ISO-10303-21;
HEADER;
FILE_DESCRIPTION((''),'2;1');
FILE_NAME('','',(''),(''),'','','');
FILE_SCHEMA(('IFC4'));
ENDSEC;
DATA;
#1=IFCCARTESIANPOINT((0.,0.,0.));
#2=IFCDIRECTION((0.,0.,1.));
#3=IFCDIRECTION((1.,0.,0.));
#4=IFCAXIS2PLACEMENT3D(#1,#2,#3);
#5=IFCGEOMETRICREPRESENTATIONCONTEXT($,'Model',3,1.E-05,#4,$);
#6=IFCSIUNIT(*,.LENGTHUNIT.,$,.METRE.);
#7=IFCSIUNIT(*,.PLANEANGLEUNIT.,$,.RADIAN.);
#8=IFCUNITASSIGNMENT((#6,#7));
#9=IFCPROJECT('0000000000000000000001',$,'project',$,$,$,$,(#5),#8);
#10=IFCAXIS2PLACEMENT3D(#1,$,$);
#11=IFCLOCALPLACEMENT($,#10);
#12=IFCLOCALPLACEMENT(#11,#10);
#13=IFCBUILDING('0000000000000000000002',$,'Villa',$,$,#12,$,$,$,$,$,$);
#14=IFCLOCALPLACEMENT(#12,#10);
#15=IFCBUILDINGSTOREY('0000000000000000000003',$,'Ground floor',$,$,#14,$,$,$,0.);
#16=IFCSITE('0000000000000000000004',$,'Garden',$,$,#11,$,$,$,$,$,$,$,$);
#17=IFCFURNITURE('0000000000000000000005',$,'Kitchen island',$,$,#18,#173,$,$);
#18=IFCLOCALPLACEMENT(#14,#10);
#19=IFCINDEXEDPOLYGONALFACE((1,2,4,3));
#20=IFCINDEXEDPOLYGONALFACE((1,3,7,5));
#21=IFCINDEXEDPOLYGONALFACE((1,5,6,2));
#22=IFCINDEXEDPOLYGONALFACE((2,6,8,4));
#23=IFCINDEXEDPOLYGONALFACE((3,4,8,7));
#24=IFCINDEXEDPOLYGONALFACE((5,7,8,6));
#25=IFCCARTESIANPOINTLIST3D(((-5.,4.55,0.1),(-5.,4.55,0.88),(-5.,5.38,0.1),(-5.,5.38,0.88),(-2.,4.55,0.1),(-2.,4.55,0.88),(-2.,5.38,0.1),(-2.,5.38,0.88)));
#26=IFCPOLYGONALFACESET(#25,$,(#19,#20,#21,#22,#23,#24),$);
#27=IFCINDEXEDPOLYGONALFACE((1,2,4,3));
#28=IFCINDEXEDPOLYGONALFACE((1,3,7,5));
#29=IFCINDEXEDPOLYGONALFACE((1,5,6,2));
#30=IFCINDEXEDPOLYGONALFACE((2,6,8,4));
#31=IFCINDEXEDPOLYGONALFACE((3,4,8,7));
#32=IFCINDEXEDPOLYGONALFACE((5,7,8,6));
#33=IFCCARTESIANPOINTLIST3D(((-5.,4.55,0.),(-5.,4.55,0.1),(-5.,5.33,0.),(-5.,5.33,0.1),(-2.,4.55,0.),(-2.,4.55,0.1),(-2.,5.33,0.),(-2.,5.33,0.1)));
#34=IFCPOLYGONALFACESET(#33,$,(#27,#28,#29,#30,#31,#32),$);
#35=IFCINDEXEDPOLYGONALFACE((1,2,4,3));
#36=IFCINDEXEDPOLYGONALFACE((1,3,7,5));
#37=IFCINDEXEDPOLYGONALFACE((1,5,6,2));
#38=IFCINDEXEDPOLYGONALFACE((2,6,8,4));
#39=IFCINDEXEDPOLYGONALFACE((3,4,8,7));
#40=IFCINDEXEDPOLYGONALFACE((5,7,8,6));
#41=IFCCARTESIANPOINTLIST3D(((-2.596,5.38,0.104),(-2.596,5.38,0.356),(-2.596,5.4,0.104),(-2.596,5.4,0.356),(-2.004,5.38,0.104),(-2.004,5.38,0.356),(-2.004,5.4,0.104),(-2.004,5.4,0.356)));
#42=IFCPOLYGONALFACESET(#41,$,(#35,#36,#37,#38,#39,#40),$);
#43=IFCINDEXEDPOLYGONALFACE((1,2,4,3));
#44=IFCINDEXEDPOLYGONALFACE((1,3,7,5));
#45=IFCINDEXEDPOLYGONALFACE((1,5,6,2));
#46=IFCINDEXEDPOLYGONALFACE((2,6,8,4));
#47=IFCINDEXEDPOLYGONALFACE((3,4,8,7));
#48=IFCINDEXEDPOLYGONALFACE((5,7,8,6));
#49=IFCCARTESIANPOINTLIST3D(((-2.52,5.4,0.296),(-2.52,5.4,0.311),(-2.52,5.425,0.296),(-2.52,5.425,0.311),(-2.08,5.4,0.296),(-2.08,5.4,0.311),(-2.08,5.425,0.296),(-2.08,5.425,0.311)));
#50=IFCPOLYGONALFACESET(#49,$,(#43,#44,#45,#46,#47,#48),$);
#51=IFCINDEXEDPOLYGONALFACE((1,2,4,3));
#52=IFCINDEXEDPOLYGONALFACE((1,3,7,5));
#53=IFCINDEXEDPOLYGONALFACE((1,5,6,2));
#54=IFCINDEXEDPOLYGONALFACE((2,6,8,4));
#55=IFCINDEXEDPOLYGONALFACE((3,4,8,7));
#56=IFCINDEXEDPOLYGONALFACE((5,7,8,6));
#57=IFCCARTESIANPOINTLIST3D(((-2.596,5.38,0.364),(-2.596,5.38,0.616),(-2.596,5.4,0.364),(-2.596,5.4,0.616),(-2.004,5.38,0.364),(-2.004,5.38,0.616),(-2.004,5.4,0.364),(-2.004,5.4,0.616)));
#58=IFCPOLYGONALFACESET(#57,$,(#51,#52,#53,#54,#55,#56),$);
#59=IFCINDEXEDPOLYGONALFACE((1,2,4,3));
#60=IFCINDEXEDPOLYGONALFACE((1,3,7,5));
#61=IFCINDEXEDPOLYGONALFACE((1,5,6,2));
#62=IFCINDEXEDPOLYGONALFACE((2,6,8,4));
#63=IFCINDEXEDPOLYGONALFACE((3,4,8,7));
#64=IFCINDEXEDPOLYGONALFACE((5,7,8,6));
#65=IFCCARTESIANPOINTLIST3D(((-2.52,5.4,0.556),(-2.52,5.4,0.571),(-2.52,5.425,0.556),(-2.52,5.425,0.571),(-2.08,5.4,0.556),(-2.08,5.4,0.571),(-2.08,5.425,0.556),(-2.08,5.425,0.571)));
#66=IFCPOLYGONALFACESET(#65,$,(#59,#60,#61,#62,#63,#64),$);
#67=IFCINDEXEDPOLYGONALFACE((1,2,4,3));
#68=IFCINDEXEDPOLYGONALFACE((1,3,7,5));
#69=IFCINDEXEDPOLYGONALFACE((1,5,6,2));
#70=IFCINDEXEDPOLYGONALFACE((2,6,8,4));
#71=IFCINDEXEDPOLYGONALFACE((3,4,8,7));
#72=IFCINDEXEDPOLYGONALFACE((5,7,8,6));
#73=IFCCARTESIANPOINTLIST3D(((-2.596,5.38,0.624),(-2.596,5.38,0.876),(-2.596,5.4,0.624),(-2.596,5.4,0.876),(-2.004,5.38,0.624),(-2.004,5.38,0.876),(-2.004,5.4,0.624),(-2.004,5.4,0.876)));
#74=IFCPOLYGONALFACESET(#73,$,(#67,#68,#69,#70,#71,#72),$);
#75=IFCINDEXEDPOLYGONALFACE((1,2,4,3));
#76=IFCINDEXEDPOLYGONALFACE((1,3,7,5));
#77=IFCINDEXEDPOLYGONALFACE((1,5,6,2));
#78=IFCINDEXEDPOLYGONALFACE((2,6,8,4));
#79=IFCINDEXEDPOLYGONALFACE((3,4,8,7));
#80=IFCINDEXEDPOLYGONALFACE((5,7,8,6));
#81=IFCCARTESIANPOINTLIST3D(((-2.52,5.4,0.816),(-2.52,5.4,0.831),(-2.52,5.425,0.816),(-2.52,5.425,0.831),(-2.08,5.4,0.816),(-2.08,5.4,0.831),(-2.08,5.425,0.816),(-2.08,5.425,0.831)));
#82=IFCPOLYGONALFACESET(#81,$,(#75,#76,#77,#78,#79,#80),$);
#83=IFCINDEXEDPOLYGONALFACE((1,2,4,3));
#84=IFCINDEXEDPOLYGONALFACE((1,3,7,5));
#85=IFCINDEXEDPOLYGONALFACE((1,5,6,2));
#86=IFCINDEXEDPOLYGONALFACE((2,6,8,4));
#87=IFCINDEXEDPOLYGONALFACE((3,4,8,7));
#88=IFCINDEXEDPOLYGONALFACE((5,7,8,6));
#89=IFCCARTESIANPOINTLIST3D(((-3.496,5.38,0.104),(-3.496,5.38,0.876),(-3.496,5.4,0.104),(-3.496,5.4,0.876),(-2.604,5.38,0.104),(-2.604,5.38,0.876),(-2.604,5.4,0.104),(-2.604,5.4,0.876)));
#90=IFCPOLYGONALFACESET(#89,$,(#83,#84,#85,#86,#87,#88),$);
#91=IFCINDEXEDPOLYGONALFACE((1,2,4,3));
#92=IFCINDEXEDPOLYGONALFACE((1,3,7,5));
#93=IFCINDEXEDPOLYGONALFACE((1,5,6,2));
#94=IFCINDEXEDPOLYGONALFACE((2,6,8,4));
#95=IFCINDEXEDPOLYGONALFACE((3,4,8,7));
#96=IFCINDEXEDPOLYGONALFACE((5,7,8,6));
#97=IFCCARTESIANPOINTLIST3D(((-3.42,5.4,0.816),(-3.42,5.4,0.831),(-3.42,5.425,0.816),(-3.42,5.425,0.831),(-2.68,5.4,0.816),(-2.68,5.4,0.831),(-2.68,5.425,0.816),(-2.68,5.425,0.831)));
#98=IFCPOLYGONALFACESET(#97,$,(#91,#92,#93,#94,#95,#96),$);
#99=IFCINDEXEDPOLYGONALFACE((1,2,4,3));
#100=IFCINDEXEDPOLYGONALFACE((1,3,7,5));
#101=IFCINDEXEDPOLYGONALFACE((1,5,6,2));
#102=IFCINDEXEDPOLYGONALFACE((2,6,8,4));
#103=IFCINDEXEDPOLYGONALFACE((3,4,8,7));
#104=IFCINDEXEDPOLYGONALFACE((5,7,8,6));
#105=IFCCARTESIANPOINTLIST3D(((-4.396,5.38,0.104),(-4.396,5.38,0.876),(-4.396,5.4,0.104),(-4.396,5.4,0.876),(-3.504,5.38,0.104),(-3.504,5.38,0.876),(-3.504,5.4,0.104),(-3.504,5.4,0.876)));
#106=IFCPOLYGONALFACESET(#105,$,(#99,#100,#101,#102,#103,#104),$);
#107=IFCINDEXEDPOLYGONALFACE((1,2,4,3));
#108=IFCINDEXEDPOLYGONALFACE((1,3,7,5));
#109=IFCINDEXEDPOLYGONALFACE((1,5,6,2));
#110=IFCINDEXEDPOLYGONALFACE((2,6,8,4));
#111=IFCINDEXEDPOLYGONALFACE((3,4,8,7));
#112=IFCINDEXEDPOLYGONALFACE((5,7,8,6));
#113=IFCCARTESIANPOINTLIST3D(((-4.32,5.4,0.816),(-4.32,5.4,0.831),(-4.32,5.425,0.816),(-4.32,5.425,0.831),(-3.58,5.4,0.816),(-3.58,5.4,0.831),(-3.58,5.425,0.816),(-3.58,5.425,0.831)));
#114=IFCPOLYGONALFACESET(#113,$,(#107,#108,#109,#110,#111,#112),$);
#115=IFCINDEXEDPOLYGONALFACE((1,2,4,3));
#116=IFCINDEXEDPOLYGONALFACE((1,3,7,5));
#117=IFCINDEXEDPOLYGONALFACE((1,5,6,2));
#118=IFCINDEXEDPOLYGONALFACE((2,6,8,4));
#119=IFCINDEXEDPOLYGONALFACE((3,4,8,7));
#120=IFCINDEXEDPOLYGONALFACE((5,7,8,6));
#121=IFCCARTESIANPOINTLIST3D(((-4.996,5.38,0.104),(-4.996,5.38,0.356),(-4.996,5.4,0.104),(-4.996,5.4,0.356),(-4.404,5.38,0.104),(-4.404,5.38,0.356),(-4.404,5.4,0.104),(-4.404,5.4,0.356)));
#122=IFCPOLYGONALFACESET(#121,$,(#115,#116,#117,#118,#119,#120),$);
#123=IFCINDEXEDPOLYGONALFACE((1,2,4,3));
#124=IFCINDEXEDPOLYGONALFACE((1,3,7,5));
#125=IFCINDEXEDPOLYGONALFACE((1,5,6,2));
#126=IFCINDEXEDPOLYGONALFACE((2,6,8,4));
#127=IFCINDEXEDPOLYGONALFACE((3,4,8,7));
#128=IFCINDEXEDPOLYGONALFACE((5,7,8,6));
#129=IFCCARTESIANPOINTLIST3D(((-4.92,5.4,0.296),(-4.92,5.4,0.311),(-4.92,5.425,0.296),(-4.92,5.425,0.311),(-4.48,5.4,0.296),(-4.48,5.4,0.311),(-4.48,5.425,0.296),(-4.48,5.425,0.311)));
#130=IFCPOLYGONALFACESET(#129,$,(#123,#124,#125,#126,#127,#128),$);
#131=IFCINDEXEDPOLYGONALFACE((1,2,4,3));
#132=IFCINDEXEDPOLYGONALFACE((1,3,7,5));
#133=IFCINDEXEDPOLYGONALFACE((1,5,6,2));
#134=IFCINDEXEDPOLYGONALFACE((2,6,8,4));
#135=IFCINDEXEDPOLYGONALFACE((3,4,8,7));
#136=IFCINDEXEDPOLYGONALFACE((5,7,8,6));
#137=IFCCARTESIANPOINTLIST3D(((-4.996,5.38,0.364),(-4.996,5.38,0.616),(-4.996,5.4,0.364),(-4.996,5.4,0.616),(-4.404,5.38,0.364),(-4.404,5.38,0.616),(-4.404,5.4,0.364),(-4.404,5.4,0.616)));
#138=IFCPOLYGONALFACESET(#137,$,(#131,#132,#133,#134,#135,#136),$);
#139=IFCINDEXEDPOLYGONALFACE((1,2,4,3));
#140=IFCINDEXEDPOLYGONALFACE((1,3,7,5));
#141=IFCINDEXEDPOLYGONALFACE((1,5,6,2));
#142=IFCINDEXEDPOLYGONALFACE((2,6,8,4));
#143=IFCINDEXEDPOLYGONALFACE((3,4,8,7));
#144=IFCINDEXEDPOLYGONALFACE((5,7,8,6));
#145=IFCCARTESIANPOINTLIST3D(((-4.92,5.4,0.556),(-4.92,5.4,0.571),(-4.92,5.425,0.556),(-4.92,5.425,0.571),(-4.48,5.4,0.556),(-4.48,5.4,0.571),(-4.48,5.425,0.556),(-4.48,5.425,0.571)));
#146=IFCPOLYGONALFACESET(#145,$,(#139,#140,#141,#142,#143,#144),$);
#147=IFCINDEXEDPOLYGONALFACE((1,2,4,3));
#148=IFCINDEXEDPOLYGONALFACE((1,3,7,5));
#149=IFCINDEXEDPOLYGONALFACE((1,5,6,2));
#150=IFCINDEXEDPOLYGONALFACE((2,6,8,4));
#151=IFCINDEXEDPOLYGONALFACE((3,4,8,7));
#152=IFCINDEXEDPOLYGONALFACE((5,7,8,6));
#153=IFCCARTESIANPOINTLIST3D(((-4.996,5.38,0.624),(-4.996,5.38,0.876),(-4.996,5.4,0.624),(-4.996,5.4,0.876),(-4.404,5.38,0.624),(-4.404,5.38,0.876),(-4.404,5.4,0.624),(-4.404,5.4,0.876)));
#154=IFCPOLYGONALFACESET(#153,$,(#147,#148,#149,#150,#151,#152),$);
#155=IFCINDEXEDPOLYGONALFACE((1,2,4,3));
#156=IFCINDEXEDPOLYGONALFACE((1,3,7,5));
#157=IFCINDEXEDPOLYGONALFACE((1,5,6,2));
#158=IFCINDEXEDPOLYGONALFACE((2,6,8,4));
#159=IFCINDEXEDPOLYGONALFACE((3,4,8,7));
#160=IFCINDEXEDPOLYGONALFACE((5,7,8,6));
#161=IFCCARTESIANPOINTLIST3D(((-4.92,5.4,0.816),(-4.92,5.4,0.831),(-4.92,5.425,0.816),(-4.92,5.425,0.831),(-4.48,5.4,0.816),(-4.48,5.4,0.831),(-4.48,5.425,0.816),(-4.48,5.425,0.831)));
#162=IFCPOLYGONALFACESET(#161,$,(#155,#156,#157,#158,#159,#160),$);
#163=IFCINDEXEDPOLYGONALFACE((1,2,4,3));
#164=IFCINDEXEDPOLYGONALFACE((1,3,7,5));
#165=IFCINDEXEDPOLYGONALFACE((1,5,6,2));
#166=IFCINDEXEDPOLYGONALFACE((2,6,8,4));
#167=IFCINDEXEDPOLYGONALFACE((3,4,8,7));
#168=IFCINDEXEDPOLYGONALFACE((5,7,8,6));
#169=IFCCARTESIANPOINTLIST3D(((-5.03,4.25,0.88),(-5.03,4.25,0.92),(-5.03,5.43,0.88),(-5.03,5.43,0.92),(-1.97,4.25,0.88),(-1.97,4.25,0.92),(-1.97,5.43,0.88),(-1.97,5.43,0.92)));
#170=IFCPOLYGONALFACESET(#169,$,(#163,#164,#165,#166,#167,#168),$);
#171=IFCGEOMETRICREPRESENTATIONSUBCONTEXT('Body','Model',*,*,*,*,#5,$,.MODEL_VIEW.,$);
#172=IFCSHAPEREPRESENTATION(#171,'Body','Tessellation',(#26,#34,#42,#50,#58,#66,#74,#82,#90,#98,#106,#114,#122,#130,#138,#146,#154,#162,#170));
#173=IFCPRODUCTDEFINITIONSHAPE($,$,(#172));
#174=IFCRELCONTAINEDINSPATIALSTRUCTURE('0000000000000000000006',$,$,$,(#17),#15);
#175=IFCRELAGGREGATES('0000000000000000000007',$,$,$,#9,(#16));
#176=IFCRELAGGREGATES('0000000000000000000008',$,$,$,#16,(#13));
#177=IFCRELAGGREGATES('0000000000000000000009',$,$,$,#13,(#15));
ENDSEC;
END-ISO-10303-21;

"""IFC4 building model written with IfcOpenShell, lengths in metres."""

from ifc_helpers import new_model, si_unit, frame, frame_2d, origin, origin_with_axes, place, context, subcontext, project, spatial, rectangle, extrude, element, save


model = new_model("IFC4")

# Units and contexts
model_context = context("Model", 3, precision=1e-05, world=origin_with_axes())
body_context = subcontext(model_context, "Body", "Model", "MODEL_VIEW")
ifc_project = project(units=[si_unit("LENGTHUNIT", "METRE"), si_unit("PLANEANGLEUNIT", "RADIAN")], contexts=[model_context])

# Site, building, storey
site_placement = place(None, origin())
site = spatial("IfcSite", under=ifc_project, at=site_placement, Name="Garden")
building_placement = place(site_placement, origin())
building = spatial("IfcBuilding", under=site, at=building_placement, Name="Villa")
storey_placement = place(building_placement, origin())
storey = spatial("IfcBuildingStorey", under=building, at=storey_placement, Name="Ground floor", Elevation=0.0)

# Furniture
furniture_1_placement = place(storey_placement, frame((-2.0, 5.4, 0.0), x_axis=(-1.0, 0.0, 0.0)))
element("IfcFurniture", 1, at=furniture_1_placement, inside=storey, Name="Kitchen island", context=body_context, shape_type="SweptSolid", body=[
    extrude(rectangle(XDim=3.0, YDim=0.83, at=frame_2d((1.5, 0.415))), frame((0.0, 0.02, 0.1)), (0.0, 0.0, 1.0), 0.78),
    extrude(rectangle(XDim=3.0, YDim=0.78, at=frame_2d((1.5, 0.39))), frame((0.0, 0.07, 0.0)), (0.0, 0.0, 1.0), 0.1),
    extrude(rectangle(XDim=0.592, YDim=0.02, at=frame_2d((0.296, 0.01))), frame((0.004, 0.0, 0.104)), (0.0, 0.0, 1.0), 0.252),
    extrude(rectangle(XDim=0.44, YDim=0.025, at=frame_2d((0.22, 0.0125))), frame((0.08, -0.025, 0.296)), (0.0, 0.0, 1.0), 0.015),
    extrude(rectangle(XDim=0.592, YDim=0.02, at=frame_2d((0.296, 0.01))), frame((0.004, 0.0, 0.364)), (0.0, 0.0, 1.0), 0.252),
    extrude(rectangle(XDim=0.44, YDim=0.025, at=frame_2d((0.22, 0.0125))), frame((0.08, -0.025, 0.556)), (0.0, 0.0, 1.0), 0.015),
    extrude(rectangle(XDim=0.592, YDim=0.02, at=frame_2d((0.296, 0.01))), frame((0.004, 0.0, 0.624)), (0.0, 0.0, 1.0), 0.252),
    extrude(rectangle(XDim=0.44, YDim=0.025, at=frame_2d((0.22, 0.0125))), frame((0.08, -0.025, 0.816)), (0.0, 0.0, 1.0), 0.015),
    extrude(rectangle(XDim=0.892, YDim=0.02, at=frame_2d((0.446, 0.01))), frame((0.604, 0.0, 0.104)), (0.0, 0.0, 1.0), 0.772),
    extrude(rectangle(XDim=0.74, YDim=0.025, at=frame_2d((0.37, 0.0125))), frame((0.68, -0.025, 0.816)), (0.0, 0.0, 1.0), 0.015),
    extrude(rectangle(XDim=0.892, YDim=0.02, at=frame_2d((0.446, 0.01))), frame((1.504, 0.0, 0.104)), (0.0, 0.0, 1.0), 0.772),
    extrude(rectangle(XDim=0.74, YDim=0.025, at=frame_2d((0.37, 0.0125))), frame((1.58, -0.025, 0.816)), (0.0, 0.0, 1.0), 0.015),
    extrude(rectangle(XDim=0.592, YDim=0.02, at=frame_2d((0.296, 0.01))), frame((2.404, 0.0, 0.104)), (0.0, 0.0, 1.0), 0.252),
    extrude(rectangle(XDim=0.44, YDim=0.025, at=frame_2d((0.22, 0.0125))), frame((2.48, -0.025, 0.296)), (0.0, 0.0, 1.0), 0.015),
    extrude(rectangle(XDim=0.592, YDim=0.02, at=frame_2d((0.296, 0.01))), frame((2.404, 0.0, 0.364)), (0.0, 0.0, 1.0), 0.252),
    extrude(rectangle(XDim=0.44, YDim=0.025, at=frame_2d((0.22, 0.0125))), frame((2.48, -0.025, 0.556)), (0.0, 0.0, 1.0), 0.015),
    extrude(rectangle(XDim=0.592, YDim=0.02, at=frame_2d((0.296, 0.01))), frame((2.404, 0.0, 0.624)), (0.0, 0.0, 1.0), 0.252),
    extrude(rectangle(XDim=0.44, YDim=0.025, at=frame_2d((0.22, 0.0125))), frame((2.48, -0.025, 0.816)), (0.0, 0.0, 1.0), 0.015),
    extrude(rectangle(XDim=3.06, YDim=1.18, at=frame_2d((1.53, 0.59))), frame((-0.03, -0.03, 0.88)), (0.0, 0.0, 1.0), 0.04),
])

save(model, "model.ifc")
